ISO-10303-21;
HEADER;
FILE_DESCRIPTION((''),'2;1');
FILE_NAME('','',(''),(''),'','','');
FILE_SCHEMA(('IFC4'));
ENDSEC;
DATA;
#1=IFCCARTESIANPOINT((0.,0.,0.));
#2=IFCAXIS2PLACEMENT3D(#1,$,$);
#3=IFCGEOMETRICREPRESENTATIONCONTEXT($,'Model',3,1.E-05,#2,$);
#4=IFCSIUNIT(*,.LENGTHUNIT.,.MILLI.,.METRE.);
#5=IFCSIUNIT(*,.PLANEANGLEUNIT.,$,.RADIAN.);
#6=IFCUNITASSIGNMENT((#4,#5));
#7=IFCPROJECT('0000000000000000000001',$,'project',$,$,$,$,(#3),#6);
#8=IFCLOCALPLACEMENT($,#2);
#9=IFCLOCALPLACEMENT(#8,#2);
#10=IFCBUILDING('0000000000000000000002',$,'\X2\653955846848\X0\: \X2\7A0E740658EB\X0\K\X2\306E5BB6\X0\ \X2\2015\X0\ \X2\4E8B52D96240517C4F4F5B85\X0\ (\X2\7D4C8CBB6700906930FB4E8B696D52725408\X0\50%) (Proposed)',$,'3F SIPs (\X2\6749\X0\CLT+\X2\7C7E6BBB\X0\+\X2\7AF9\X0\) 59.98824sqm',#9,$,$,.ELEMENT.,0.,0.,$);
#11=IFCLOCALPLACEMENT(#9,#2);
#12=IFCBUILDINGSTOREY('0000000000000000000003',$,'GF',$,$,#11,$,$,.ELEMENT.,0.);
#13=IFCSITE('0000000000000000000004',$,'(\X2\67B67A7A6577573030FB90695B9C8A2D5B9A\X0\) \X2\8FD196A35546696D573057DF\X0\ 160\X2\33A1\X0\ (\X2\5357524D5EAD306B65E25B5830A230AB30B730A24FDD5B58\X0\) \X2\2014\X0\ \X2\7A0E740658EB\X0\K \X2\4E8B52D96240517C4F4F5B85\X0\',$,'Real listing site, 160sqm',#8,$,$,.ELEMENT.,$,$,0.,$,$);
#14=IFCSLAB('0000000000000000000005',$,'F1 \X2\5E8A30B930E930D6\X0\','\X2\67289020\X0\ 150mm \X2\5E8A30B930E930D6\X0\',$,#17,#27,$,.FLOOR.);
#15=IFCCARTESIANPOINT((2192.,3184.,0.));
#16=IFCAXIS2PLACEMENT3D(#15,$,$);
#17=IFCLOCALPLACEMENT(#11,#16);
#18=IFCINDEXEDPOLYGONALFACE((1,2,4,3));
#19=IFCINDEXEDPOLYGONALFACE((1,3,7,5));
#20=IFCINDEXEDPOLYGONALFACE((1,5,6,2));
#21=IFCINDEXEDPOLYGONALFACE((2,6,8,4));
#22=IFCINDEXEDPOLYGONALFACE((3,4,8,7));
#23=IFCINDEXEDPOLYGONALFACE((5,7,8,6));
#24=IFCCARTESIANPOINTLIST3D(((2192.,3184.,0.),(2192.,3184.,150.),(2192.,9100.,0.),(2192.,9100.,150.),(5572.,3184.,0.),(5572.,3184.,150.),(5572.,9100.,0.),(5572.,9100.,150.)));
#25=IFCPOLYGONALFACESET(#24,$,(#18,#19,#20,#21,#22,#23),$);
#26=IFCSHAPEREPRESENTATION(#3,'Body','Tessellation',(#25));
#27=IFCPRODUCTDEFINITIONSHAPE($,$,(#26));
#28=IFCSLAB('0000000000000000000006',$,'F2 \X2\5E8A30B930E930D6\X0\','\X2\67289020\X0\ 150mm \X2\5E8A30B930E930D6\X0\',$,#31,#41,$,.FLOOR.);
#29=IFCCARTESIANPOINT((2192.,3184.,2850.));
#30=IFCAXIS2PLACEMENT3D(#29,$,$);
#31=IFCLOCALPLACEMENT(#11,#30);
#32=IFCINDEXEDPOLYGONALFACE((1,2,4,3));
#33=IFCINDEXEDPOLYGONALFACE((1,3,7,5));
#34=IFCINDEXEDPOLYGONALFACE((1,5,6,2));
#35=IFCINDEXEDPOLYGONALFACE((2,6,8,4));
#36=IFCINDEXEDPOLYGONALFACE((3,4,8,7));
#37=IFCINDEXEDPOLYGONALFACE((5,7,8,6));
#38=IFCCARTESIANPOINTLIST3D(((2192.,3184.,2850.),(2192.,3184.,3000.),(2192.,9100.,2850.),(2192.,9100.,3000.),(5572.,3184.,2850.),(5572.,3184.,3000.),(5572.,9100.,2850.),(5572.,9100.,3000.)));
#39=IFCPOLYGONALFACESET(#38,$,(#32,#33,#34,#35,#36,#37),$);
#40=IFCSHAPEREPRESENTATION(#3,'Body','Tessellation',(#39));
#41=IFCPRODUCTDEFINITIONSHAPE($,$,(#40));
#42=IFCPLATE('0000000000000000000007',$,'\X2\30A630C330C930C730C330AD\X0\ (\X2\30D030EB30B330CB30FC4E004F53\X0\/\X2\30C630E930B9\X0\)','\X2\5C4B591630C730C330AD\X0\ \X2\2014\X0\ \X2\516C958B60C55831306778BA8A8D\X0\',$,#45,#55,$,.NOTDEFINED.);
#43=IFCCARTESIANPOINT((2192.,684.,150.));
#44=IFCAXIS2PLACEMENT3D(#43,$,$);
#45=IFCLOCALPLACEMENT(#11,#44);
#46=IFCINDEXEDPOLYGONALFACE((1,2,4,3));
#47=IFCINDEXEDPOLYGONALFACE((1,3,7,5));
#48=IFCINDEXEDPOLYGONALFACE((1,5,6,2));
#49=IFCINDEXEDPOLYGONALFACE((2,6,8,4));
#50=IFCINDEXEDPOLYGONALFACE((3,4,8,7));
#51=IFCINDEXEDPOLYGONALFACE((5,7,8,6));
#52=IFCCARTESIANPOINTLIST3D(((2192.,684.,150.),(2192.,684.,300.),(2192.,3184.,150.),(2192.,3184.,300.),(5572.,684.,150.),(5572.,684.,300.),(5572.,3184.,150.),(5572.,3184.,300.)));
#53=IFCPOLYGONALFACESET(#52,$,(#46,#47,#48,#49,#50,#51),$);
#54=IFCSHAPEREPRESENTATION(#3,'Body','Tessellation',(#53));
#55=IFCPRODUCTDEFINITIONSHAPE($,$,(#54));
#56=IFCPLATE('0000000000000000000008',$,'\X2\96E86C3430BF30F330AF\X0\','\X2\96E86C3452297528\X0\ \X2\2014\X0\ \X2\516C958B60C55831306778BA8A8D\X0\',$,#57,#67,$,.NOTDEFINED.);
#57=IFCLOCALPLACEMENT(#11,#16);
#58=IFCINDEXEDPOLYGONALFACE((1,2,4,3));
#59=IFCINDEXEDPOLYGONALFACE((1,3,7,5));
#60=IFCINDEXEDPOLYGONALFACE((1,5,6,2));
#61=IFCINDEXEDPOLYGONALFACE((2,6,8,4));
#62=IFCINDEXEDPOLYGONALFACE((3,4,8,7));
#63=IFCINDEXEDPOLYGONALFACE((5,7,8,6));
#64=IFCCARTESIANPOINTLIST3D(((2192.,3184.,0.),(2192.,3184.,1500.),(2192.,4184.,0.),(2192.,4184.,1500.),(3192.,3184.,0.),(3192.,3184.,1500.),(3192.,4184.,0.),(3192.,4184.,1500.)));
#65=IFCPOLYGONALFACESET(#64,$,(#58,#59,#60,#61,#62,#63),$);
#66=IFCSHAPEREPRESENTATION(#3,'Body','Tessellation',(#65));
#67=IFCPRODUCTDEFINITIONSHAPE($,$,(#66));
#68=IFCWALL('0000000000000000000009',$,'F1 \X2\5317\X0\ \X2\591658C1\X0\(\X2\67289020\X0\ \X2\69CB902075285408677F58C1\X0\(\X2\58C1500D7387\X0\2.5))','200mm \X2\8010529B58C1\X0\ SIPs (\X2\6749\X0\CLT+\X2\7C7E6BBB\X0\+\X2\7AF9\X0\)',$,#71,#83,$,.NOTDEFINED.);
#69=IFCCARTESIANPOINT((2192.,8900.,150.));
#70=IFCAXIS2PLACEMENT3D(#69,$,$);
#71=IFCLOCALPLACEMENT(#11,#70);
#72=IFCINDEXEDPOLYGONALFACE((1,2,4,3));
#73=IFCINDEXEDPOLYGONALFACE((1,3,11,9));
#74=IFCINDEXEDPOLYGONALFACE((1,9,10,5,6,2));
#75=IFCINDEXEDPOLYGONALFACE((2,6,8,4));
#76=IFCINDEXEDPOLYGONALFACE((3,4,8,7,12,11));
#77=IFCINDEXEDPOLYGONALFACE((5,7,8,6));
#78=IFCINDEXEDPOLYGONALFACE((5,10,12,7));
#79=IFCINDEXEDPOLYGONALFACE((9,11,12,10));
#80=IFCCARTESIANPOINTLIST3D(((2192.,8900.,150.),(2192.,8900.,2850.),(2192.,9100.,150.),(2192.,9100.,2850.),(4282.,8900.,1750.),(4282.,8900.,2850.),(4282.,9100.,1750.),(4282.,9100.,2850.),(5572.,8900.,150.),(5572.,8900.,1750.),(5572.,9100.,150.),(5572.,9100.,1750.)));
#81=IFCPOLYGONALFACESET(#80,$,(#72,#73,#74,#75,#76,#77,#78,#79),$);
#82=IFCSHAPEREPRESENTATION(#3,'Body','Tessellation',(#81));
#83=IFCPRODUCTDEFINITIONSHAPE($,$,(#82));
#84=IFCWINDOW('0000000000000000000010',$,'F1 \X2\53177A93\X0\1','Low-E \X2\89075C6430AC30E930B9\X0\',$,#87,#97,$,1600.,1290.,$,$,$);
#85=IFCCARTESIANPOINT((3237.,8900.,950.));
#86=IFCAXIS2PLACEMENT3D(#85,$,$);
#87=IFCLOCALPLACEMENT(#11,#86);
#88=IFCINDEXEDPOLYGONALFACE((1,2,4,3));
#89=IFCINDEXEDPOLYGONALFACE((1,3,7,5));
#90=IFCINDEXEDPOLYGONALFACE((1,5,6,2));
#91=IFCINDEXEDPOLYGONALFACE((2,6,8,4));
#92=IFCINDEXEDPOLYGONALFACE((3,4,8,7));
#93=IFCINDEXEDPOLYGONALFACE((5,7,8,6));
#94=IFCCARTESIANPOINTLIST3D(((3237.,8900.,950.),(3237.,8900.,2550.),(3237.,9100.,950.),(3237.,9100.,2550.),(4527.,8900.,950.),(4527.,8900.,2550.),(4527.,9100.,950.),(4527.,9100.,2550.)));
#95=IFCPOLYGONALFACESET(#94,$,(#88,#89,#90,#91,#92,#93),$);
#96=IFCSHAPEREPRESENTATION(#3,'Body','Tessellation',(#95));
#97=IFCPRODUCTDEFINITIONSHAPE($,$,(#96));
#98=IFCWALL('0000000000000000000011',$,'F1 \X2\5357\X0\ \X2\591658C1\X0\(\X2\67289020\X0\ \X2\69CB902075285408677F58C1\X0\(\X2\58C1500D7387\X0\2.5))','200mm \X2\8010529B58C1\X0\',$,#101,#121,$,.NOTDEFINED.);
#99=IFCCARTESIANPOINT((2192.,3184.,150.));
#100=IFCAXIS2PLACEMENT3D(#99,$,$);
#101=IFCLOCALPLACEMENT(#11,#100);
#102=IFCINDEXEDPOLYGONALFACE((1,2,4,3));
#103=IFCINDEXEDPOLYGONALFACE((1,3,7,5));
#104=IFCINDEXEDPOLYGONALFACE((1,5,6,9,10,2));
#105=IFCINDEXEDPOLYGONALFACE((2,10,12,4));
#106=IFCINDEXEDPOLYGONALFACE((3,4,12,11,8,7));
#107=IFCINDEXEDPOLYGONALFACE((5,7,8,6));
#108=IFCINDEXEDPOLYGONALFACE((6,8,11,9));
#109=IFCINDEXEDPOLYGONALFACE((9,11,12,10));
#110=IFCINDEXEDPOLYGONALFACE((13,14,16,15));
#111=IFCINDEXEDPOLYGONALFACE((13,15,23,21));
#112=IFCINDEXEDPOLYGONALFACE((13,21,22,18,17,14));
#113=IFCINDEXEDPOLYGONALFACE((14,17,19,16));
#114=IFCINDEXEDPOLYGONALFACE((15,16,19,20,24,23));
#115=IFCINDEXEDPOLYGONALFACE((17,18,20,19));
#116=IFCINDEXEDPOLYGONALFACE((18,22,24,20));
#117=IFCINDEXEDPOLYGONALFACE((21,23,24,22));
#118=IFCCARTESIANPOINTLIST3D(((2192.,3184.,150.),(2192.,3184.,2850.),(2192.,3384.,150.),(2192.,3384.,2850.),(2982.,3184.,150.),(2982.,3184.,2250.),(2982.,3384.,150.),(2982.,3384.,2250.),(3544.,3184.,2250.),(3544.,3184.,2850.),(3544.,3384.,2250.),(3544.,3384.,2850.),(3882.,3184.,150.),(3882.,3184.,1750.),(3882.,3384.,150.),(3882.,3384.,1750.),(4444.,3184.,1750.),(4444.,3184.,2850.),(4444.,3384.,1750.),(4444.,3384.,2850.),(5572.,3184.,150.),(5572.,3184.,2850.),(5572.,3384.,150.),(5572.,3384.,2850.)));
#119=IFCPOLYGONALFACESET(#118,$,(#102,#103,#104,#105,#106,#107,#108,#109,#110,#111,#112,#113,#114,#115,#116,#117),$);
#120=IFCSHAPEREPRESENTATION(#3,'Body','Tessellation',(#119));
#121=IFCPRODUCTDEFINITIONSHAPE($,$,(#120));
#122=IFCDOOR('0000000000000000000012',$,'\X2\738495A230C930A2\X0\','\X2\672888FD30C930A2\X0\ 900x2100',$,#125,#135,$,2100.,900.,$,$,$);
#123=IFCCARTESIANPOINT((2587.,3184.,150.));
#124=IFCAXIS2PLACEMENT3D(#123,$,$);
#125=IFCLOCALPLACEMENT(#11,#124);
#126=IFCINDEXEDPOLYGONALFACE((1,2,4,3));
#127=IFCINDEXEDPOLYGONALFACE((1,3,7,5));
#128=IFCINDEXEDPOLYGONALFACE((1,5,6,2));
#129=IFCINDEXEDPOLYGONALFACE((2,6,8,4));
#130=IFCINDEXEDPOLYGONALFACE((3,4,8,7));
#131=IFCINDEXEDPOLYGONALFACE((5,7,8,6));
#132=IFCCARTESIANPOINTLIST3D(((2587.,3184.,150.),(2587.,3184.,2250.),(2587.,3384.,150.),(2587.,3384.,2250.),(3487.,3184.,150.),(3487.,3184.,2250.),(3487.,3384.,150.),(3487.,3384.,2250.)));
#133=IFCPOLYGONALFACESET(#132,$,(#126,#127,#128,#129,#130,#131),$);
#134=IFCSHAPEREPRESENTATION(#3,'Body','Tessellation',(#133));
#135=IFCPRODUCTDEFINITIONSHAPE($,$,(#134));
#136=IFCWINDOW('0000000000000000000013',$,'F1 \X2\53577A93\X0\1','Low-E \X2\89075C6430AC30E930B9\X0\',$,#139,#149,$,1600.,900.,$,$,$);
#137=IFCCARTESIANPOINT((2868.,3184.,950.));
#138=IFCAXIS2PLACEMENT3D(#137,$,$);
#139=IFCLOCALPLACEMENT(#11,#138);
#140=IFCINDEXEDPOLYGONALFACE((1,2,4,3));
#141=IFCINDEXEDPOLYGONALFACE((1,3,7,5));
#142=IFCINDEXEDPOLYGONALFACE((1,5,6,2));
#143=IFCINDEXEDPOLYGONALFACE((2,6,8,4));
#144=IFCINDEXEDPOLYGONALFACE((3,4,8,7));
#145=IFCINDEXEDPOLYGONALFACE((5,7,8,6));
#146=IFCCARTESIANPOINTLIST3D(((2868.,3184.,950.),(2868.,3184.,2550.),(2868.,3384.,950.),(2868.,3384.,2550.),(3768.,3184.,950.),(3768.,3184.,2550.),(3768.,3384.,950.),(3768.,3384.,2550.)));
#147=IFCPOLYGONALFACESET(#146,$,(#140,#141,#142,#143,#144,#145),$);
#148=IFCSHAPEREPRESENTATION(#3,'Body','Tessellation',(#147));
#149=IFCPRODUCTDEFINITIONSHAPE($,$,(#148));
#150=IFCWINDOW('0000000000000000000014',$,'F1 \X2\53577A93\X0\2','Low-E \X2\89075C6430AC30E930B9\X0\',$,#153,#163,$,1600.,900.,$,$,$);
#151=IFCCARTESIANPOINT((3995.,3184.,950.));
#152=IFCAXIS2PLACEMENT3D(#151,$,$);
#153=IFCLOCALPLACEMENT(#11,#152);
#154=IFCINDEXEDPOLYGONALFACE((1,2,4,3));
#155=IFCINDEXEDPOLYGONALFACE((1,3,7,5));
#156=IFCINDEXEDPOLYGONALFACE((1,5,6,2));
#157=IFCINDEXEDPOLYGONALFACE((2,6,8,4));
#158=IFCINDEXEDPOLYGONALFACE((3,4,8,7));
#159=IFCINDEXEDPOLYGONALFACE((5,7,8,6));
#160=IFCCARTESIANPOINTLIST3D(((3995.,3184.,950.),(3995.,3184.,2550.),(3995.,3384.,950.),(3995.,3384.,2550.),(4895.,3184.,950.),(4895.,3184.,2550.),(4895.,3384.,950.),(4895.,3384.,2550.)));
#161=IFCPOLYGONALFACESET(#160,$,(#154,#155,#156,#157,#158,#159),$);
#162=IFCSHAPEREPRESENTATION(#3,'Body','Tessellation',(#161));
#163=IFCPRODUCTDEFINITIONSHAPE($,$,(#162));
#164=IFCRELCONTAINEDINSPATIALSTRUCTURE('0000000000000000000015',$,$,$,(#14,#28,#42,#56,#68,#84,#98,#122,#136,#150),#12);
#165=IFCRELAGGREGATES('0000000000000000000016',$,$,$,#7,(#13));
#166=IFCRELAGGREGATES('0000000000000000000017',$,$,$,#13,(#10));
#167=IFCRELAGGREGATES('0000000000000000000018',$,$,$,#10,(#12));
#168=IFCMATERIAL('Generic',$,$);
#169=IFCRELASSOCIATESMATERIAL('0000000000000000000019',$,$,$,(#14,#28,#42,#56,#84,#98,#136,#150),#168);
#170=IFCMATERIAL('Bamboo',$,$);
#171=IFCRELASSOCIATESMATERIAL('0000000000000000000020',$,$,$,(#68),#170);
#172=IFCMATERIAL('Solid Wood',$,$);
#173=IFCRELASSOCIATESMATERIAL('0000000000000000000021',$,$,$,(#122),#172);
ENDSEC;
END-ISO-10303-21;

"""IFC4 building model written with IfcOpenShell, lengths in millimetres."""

from ifc_helpers import new_model, si_unit, frame, frame_2d, origin, place, context, project, spatial, rectangle, extrude, material, element, fill, save


model = new_model("IFC4")

# Units and contexts
model_context = context("Model", 3, precision=1e-05, world=origin())
ifc_project = project(units=[si_unit("LENGTHUNIT", "METRE", prefix="MILLI"), si_unit("PLANEANGLEUNIT", "RADIAN")], contexts=[model_context])

# Site, building, storey
site_placement = place(None, origin())
site = spatial("IfcSite", under=ifc_project, at=site_placement, Name="(架空敷地・適宜設定) 近隣商業地域 160㎡ (南前庭に既存アカシア保存) — 税理士K 事務所兼住宅", ObjectType="Real listing site, 160sqm", CompositionType="ELEMENT", RefElevation=0.0)
building_placement = place(site_placement, origin())
building = spatial("IfcBuilding", under=site, at=building_placement, Name="改善案: 税理士Kの家 ― 事務所兼住宅 (経費最適・事業割合50%) (Proposed)", ObjectType="3F SIPs (杉CLT+籾殻+竹) 59.98824sqm", CompositionType="ELEMENT", ElevationOfRefHeight=0.0, ElevationOfTerrain=0.0)
storey_placement = place(building_placement, origin())
storey = spatial("IfcBuildingStorey", under=building, at=storey_placement, Name="GF", CompositionType="ELEMENT", Elevation=0.0)

# Slabs
ifc_material_1 = material(Name="Generic")
slab_1_placement = place(storey_placement, frame((2192.0, 3184.0, 0.0)))
element("IfcSlab", 1, at=slab_1_placement, inside=storey, material=ifc_material_1, Name="F1 床スラブ", Description="木造 150mm 床スラブ", PredefinedType="FLOOR", context=model_context, shape_type="SweptSolid", body=[
    extrude(rectangle(XDim=3380.0, YDim=5916.0, at=frame_2d((1690.0, 2958.0))), frame((2192.0, 3184.0, 0.0)), (0.0, 0.0, 1.0), 150.0),
])
slab_2_placement = place(storey_placement, frame((2192.0, 3184.0, 2850.0)))
element("IfcSlab", 2, at=slab_2_placement, inside=storey, material=ifc_material_1, Name="F2 床スラブ", Description="木造 150mm 床スラブ", PredefinedType="FLOOR", context=model_context, shape_type="SweptSolid", body=[
    extrude(rectangle(XDim=3380.0, YDim=5916.0, at=frame_2d((1690.0, 2958.0))), frame((2192.0, 3184.0, 2850.0)), (0.0, 0.0, 1.0), 150.0),
])

# Plates
plate_1_placement = place(storey_placement, frame((2192.0, 684.0, 150.0)))
element("IfcPlate", 3, at=plate_1_placement, inside=storey, material=ifc_material_1, Name="ウッドデッキ (バルコニー一体/テラス)", Description="屋外デッキ — 公開情報で確認", PredefinedType="NOTDEFINED", context=model_context, shape_type="SweptSolid", body=[
    extrude(rectangle(XDim=3380.0, YDim=2500.0, at=frame_2d((1690.0, 1250.0))), frame((2192.0, 684.0, 150.0)), (0.0, 0.0, 1.0), 150.0),
])
plate_2_placement = place(storey_placement, frame((2192.0, 3184.0, 0.0)))
element("IfcPlate", 4, at=plate_2_placement, inside=storey, material=ifc_material_1, Name="雨水タンク", Description="雨水利用 — 公開情報で確認", PredefinedType="NOTDEFINED", context=model_context, shape_type="SweptSolid", body=[
    extrude(rectangle(XDim=1000.0, YDim=1000.0, at=frame_2d((500.0, 500.0))), frame((2192.0, 3184.0, 0.0)), (0.0, 0.0, 1.0), 1500.0),
])

# Wall, opening, window
ifc_material_2 = material(Name="Bamboo")
wall_1_placement = place(storey_placement, frame((2192.0, 8900.0, 150.0)))
wall_1 = element("IfcWall", 5, at=wall_1_placement, inside=storey, material=ifc_material_2, Name="F1 北 外壁(木造 構造用合板壁(壁倍率2.5))", Description="200mm 耐力壁 SIPs (杉CLT+籾殻+竹)", PredefinedType="NOTDEFINED", context=model_context, shape_type="SweptSolid", body=[
    extrude(rectangle(XDim=3380.0, YDim=200.0, at=frame_2d((1690.0, 100.0))), frame((2192.0, 8900.0, 150.0)), (0.0, 0.0, 1.0), 2700.0),
])
opening_1_placement = place(storey_placement, frame((3237.0, 8900.0, 950.0)))
opening_1 = element("IfcOpeningElement", 6, at=opening_1_placement, cuts=wall_1, PredefinedType="NOTDEFINED", context=model_context, shape_type="SweptSolid", body=[
    extrude(rectangle(XDim=1290.0, YDim=200.0, at=frame_2d((645.0, 100.0))), frame((3237.0, 8900.0, 950.0)), (0.0, 0.0, 1.0), 1600.0),
])
window_1_placement = place(storey_placement, frame((3237.0, 8900.0, 950.0)))
window_1 = element("IfcWindow", 7, at=window_1_placement, inside=storey, material=ifc_material_1, Name="F1 北窓1", Description="Low-E 複層ガラス", OverallHeight=1600.0, OverallWidth=1290.0, context=model_context, shape_type="SweptSolid", body=[
    extrude(rectangle(XDim=1290.0, YDim=200.0, at=frame_2d((645.0, 100.0))), frame((3237.0, 8900.0, 950.0)), (0.0, 0.0, 1.0), 1600.0),
])
fill(opening_1, window_1)

# Wall, openings, door, windows
wall_2_placement = place(storey_placement, frame((2192.0, 3184.0, 150.0)))
wall_2 = element("IfcWall", 8, at=wall_2_placement, inside=storey, material=ifc_material_1, Name="F1 南 外壁(木造 構造用合板壁(壁倍率2.5))", Description="200mm 耐力壁", PredefinedType="NOTDEFINED", context=model_context, shape_type="SweptSolid", body=[
    extrude(rectangle(XDim=3380.0, YDim=200.0, at=frame_2d((1690.0, 100.0))), frame((2192.0, 3184.0, 150.0)), (0.0, 0.0, 1.0), 2700.0),
])
opening_2_placement = place(storey_placement, frame((2587.0, 3184.0, 150.0)))
opening_2 = element("IfcOpeningElement", 9, at=opening_2_placement, cuts=wall_2, PredefinedType="NOTDEFINED", context=model_context, shape_type="SweptSolid", body=[
    extrude(rectangle(XDim=900.0, YDim=200.0, at=frame_2d((450.0, 100.0))), frame((2587.0, 3184.0, 150.0)), (0.0, 0.0, 1.0), 2100.0),
])
opening_3_placement = place(storey_placement, frame((2868.0, 3184.0, 950.0)))
opening_3 = element("IfcOpeningElement", 10, at=opening_3_placement, cuts=wall_2, PredefinedType="NOTDEFINED", context=model_context, shape_type="SweptSolid", body=[
    extrude(rectangle(XDim=900.0, YDim=200.0, at=frame_2d((450.0, 100.0))), frame((2868.0, 3184.0, 950.0)), (0.0, 0.0, 1.0), 1600.0),
])
opening_4_placement = place(storey_placement, frame((3995.0, 3184.0, 950.0)))
opening_4 = element("IfcOpeningElement", 11, at=opening_4_placement, cuts=wall_2, PredefinedType="NOTDEFINED", context=model_context, shape_type="SweptSolid", body=[
    extrude(rectangle(XDim=900.0, YDim=200.0, at=frame_2d((450.0, 100.0))), frame((3995.0, 3184.0, 950.0)), (0.0, 0.0, 1.0), 1600.0),
])
ifc_material_3 = material(Name="Solid Wood")
door_placement = place(storey_placement, frame((2587.0, 3184.0, 150.0)))
door = element("IfcDoor", 12, at=door_placement, inside=storey, material=ifc_material_3, Name="玄関ドア", Description="木製ドア 900x2100", OverallHeight=2100.0, OverallWidth=900.0, context=model_context, shape_type="SweptSolid", body=[
    extrude(rectangle(XDim=900.0, YDim=200.0, at=frame_2d((450.0, 100.0))), frame((2587.0, 3184.0, 150.0)), (0.0, 0.0, 1.0), 2100.0),
])
fill(opening_2, door)
window_2_placement = place(storey_placement, frame((2868.0, 3184.0, 950.0)))
window_2 = element("IfcWindow", 13, at=window_2_placement, inside=storey, material=ifc_material_1, Name="F1 南窓1", Description="Low-E 複層ガラス", OverallHeight=1600.0, OverallWidth=900.0, context=model_context, shape_type="SweptSolid", body=[
    extrude(rectangle(XDim=900.0, YDim=200.0, at=frame_2d((450.0, 100.0))), frame((2868.0, 3184.0, 950.0)), (0.0, 0.0, 1.0), 1600.0),
])
fill(opening_3, window_2)
window_3_placement = place(storey_placement, frame((3995.0, 3184.0, 950.0)))
window_3 = element("IfcWindow", 14, at=window_3_placement, inside=storey, material=ifc_material_1, Name="F1 南窓2", Description="Low-E 複層ガラス", OverallHeight=1600.0, OverallWidth=900.0, context=model_context, shape_type="SweptSolid", body=[
    extrude(rectangle(XDim=900.0, YDim=200.0, at=frame_2d((450.0, 100.0))), frame((3995.0, 3184.0, 950.0)), (0.0, 0.0, 1.0), 1600.0),
])
fill(opening_4, window_3)

save(model, "model.ifc")
